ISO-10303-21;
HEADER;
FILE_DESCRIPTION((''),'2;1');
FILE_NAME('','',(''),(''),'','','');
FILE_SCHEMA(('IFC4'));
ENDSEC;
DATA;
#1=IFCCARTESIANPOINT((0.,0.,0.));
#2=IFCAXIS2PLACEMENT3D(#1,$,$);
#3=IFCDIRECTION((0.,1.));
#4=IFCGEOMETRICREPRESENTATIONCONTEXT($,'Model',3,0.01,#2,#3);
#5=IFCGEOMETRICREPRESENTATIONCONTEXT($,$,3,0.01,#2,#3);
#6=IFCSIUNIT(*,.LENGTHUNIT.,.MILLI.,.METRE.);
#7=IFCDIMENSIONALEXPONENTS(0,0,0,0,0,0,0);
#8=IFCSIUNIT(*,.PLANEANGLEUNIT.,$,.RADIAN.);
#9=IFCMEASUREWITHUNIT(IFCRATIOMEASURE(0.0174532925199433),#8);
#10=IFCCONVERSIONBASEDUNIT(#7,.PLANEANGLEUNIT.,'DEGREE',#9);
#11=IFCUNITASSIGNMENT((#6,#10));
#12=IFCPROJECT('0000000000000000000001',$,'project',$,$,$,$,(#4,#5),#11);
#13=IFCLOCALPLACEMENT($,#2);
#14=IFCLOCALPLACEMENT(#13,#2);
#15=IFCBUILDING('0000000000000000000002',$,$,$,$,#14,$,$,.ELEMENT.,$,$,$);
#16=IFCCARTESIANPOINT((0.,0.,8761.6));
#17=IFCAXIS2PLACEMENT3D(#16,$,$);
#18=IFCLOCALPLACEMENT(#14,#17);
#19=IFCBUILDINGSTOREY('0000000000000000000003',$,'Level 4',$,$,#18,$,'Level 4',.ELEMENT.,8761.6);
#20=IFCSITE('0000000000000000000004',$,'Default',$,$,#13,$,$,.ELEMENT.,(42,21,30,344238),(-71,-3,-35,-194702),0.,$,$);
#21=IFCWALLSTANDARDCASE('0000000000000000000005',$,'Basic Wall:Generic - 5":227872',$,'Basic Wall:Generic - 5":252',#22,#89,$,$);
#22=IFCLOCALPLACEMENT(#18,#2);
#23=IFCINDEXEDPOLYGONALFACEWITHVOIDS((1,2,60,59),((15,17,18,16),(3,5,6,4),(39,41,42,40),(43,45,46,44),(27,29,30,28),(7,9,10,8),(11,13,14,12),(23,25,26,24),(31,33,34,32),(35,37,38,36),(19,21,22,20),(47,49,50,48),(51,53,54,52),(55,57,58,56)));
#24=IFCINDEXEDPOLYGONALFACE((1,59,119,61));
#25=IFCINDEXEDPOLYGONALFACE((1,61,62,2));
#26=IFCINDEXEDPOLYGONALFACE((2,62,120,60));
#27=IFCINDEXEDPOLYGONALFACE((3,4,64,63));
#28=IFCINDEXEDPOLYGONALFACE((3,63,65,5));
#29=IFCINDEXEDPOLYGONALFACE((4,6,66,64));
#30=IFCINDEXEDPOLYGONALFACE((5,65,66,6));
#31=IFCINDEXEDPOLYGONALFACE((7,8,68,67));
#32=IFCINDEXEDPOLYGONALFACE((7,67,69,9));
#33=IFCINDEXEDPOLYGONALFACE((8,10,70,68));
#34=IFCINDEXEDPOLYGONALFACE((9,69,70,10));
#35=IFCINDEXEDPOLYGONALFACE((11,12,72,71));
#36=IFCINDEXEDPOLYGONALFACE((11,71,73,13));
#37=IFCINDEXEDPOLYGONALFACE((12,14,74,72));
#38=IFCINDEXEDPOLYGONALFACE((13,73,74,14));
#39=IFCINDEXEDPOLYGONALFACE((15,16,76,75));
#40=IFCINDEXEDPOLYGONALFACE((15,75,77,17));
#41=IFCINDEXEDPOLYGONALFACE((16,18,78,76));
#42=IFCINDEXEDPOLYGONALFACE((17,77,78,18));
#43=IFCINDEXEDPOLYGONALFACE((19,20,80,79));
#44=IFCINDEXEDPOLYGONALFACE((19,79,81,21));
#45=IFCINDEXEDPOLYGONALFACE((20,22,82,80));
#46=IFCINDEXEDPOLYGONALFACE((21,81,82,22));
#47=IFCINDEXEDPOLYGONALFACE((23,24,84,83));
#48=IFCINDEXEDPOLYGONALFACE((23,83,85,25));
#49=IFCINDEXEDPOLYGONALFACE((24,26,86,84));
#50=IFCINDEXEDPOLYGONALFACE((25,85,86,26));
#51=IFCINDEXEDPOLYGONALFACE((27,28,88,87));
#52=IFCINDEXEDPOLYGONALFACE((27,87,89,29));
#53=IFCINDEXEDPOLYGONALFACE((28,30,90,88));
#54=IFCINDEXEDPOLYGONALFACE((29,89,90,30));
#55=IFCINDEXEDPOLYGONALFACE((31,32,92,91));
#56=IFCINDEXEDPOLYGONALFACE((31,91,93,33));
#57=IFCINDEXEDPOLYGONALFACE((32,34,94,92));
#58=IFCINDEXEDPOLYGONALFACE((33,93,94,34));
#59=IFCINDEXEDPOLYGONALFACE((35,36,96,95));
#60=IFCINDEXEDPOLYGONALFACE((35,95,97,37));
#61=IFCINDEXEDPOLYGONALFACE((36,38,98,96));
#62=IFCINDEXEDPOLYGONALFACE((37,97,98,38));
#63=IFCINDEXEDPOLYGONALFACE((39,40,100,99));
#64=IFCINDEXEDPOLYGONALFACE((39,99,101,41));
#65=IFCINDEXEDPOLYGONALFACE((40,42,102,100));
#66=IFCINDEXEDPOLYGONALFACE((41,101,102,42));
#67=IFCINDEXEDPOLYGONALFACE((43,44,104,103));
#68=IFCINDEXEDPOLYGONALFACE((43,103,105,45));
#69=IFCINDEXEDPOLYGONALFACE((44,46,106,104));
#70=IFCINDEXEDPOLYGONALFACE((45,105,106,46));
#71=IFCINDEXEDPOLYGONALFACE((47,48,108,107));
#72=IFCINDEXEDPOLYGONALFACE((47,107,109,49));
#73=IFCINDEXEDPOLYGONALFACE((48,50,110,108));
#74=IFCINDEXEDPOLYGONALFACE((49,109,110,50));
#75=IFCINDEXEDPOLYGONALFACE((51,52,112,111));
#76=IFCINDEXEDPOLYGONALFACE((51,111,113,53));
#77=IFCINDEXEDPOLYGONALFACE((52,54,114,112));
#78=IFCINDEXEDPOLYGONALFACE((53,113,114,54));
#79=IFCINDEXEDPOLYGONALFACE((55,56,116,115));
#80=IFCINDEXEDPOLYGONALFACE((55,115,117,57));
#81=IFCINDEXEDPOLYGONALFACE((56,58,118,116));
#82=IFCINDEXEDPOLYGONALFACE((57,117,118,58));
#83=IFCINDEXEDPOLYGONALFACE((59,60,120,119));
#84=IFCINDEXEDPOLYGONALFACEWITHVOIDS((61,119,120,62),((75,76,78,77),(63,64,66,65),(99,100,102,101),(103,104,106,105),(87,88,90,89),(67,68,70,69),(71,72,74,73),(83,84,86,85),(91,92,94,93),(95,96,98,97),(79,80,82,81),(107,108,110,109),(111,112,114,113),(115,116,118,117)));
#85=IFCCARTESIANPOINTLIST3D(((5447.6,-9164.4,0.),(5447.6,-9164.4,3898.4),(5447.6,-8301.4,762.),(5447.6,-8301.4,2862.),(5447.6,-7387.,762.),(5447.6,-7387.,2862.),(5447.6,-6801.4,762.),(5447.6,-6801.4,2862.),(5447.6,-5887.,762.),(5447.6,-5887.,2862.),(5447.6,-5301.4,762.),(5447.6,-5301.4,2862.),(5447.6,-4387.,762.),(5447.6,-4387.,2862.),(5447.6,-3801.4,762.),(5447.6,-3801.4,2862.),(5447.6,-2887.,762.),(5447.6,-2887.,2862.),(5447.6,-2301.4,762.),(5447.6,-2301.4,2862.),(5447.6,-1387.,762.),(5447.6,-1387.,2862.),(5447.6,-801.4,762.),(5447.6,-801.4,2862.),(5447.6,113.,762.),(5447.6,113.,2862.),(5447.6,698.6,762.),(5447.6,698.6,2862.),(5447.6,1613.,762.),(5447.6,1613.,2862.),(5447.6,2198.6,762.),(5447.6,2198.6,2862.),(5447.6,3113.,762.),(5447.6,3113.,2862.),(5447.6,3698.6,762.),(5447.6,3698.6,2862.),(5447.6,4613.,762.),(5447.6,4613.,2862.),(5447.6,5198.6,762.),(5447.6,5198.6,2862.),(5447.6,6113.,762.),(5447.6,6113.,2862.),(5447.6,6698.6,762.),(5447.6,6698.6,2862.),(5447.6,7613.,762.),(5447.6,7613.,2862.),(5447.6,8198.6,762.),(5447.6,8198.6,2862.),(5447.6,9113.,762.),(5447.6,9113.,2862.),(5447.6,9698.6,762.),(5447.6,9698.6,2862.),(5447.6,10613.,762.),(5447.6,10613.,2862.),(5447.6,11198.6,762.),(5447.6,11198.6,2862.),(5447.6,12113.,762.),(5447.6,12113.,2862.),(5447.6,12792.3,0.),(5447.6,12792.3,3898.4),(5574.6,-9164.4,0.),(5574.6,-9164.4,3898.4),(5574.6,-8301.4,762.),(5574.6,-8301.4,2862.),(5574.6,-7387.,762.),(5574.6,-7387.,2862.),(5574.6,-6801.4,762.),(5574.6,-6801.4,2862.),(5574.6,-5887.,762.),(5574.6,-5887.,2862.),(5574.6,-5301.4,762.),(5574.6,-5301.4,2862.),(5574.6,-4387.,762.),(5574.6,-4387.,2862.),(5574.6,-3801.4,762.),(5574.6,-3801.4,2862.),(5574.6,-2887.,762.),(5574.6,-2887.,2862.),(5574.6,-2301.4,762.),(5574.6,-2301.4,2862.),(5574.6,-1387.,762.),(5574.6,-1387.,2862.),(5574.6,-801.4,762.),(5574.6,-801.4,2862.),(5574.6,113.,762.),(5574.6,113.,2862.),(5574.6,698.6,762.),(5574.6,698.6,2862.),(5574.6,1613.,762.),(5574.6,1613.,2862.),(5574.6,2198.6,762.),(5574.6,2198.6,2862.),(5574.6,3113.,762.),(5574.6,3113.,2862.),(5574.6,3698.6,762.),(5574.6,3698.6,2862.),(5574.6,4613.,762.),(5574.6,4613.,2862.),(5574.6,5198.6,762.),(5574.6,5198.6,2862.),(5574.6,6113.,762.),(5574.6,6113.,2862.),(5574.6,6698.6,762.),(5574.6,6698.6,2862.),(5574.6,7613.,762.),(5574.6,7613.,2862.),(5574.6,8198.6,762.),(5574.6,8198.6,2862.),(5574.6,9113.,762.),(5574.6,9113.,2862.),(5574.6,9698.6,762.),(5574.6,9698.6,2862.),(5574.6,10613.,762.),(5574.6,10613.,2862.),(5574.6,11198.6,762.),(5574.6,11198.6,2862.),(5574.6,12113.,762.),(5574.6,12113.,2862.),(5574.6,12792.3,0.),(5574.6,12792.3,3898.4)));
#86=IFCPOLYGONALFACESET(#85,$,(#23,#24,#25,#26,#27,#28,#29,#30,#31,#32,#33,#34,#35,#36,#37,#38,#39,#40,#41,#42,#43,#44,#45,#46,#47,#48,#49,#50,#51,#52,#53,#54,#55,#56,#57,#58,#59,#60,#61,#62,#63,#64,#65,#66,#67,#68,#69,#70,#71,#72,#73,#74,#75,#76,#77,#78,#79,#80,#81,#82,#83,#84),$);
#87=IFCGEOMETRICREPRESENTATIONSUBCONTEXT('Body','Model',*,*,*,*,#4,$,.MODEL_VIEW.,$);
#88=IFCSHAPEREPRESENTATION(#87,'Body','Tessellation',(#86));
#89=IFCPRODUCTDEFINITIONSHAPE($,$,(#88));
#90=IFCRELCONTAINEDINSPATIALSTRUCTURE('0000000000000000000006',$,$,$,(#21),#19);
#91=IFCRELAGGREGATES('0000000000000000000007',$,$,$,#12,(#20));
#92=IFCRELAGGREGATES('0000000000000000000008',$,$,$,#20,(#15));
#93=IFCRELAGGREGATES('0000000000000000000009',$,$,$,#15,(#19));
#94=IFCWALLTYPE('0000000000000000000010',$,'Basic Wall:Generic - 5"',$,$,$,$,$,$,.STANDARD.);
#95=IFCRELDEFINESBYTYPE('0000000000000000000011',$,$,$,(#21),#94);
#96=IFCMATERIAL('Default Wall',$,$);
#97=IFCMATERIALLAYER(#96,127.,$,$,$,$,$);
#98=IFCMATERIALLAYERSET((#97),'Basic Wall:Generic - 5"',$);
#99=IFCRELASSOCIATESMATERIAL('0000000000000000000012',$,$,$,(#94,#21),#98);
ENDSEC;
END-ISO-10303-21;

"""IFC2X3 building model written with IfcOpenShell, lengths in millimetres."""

from ifc_helpers import new_model, entity, si_unit, converted_unit, direction, frame, frame_2d, origin, place, context, subcontext, project, spatial, polyline, rectangle, extrude, clip, bounded_halfspace, material, layer, layer_set, layer_usage, type_object, element, save


model = new_model("IFC2X3")

# Units and contexts
model_context = context("Model", 3, precision=0.01, world=origin(), true_north=direction((0.0, 1.0)))
context_of_model = context(None, 3, precision=0.01, world=origin(), true_north=direction((0.0, 1.0)))
body_context = subcontext(model_context, "Body", "Model", "MODEL_VIEW")
ifc_project = project(units=[si_unit("LENGTHUNIT", "METRE", prefix="MILLI"), converted_unit("PLANEANGLEUNIT", "DEGREE", entity("IfcRatioMeasure", 0.0174532925199433), si_unit("PLANEANGLEUNIT", "RADIAN"), dimensions=[0, 0, 0, 0, 0, 0, 0])], contexts=[model_context, context_of_model])

# Site, building, storey
site_placement = place(None, origin())
site = spatial("IfcSite", under=ifc_project, at=site_placement, Name="Default", CompositionType="ELEMENT", RefLatitude=(42, 21, 30, 344238), RefLongitude=(-71, -3, -35, -194702), RefElevation=0.0)
building_placement = place(site_placement, origin())
building = spatial("IfcBuilding", under=site, at=building_placement, CompositionType="ELEMENT")
storey_placement = place(building_placement, frame((0.0, 0.0, 8761.6)))
storey = spatial("IfcBuildingStorey", under=building, at=storey_placement, Name="Level 4", LongName="Level 4", CompositionType="ELEMENT", Elevation=8761.6)

# Wall, openings
ifc_material_1 = material(Name="Default Wall")
ifc_layer_1 = layer(ifc_material_1, 127.0)
ifc_layer_set_1 = layer_set([ifc_layer_1], Name="Basic Wall:Generic - 5\"")
wall_type = type_object("IfcWallType", Name="Basic Wall:Generic - 5\"", PredefinedType="STANDARD", material=ifc_layer_set_1)
ifc_layer_usage_1 = layer_usage(ifc_layer_set_1, "AXIS2", "NEGATIVE", 63.5)
wall_1_placement = place(storey_placement, frame((5511.1, 12792.3, 0.0), z_axis=(0.0, 0.0, 1.0), x_axis=(0.0, -1.0, 0.0)))
wall_1 = element("IfcWallStandardCase", 1, at=wall_1_placement, inside=storey, type_object=wall_type, material=ifc_layer_usage_1, Name="Basic Wall:Generic - 5\":227872", ObjectType="Basic Wall:Generic - 5\":252", context=body_context, shape_type="Clipping", body=[
    clip(extrude(rectangle(XDim=21956.7, YDim=127.0, at=frame_2d((10978.4, 0.0), x_axis=(-1.0, 0.0))), origin(), (0.0, 0.0, 1.0), 3898.4), bounded_halfspace(frame((0.0, -63.5, 3898.4), z_axis=(0.0, 0.0, -1.0), x_axis=(1.0, 0.0, 0.0)), True, frame((0.0, -63.5, 3898.4)), polyline([(0.0, 0.0), (21829.7, 0.0), (21956.7, 0.0), (21956.7, 127.0), (0.0, 127.0), (0.0, 0.0)]))),
])
opening_1_placement = place(wall_1_placement, frame((679.3, -63.5, 762.0)))
element("IfcOpeningElement", 2, at=opening_1_placement, cuts=wall_1, ObjectType="Opening", context=body_context, shape_type="SweptSolid", body=[
    extrude(rectangle(XDim=2100.0, YDim=914.4, at=frame_2d((1050.0, 457.2), x_axis=(-1.0, 0.0))), frame((0.0, 0.0, 0.0), z_axis=(0.0, 1.0, 0.0), x_axis=(0.0, 0.0, 1.0)), (0.0, 0.0, 1.0), 127.0),
])
opening_2_placement = place(wall_1_placement, frame((3679.3, -63.5, 762.0)))
element("IfcOpeningElement", 3, at=opening_2_placement, cuts=wall_1, ObjectType="Opening", context=body_context, shape_type="SweptSolid", body=[
    extrude(rectangle(XDim=2100.0, YDim=914.4, at=frame_2d((1050.0, 457.2), x_axis=(-1.0, 0.0))), frame((0.0, 0.0, 0.0), z_axis=(0.0, 1.0, 0.0), x_axis=(0.0, 0.0, 1.0)), (0.0, 0.0, 1.0), 127.0),
])
opening_3_placement = place(wall_1_placement, frame((6679.3, -63.5, 762.0)))
element("IfcOpeningElement", 4, at=opening_3_placement, cuts=wall_1, ObjectType="Opening", context=body_context, shape_type="SweptSolid", body=[
    extrude(rectangle(XDim=2100.0, YDim=914.4, at=frame_2d((1050.0, 457.2), x_axis=(-1.0, 0.0))), frame((0.0, 0.0, 0.0), z_axis=(0.0, 1.0, 0.0), x_axis=(0.0, 0.0, 1.0)), (0.0, 0.0, 1.0), 127.0),
])
opening_4_placement = place(wall_1_placement, frame((9679.3, -63.5, 762.0)))
element("IfcOpeningElement", 5, at=opening_4_placement, cuts=wall_1, ObjectType="Opening", context=body_context, shape_type="SweptSolid", body=[
    extrude(rectangle(XDim=2100.0, YDim=914.4, at=frame_2d((1050.0, 457.2), x_axis=(-1.0, 0.0))), frame((0.0, 0.0, 0.0), z_axis=(0.0, 1.0, 0.0), x_axis=(0.0, 0.0, 1.0)), (0.0, 0.0, 1.0), 127.0),
])
opening_5_placement = place(wall_1_placement, frame((12679.3, -63.5, 762.0)))
element("IfcOpeningElement", 6, at=opening_5_placement, cuts=wall_1, ObjectType="Opening", context=body_context, shape_type="SweptSolid", body=[
    extrude(rectangle(XDim=2100.0, YDim=914.4, at=frame_2d((1050.0, 457.2), x_axis=(-1.0, 0.0))), frame((0.0, 0.0, 0.0), z_axis=(0.0, 1.0, 0.0), x_axis=(0.0, 0.0, 1.0)), (0.0, 0.0, 1.0), 127.0),
])
opening_6_placement = place(wall_1_placement, frame((15679.3, -63.5, 762.0)))
element("IfcOpeningElement", 7, at=opening_6_placement, cuts=wall_1, ObjectType="Opening", context=body_context, shape_type="SweptSolid", body=[
    extrude(rectangle(XDim=2100.0, YDim=914.4, at=frame_2d((1050.0, 457.2), x_axis=(-1.0, 0.0))), frame((0.0, 0.0, 0.0), z_axis=(0.0, 1.0, 0.0), x_axis=(0.0, 0.0, 1.0)), (0.0, 0.0, 1.0), 127.0),
])
opening_7_placement = place(wall_1_placement, frame((18679.3, -63.5, 762.0)))
element("IfcOpeningElement", 8, at=opening_7_placement, cuts=wall_1, ObjectType="Opening", context=body_context, shape_type="SweptSolid", body=[
    extrude(rectangle(XDim=2100.0, YDim=914.4, at=frame_2d((1050.0, 457.2), x_axis=(-1.0, 0.0))), frame((0.0, 0.0, 0.0), z_axis=(0.0, 1.0, 0.0), x_axis=(0.0, 0.0, 1.0)), (0.0, 0.0, 1.0), 127.0),
])
opening_8_placement = place(wall_1_placement, frame((2179.3, -63.5, 762.0)))
element("IfcOpeningElement", 9, at=opening_8_placement, cuts=wall_1, ObjectType="Opening", context=body_context, shape_type="SweptSolid", body=[
    extrude(rectangle(XDim=2100.0, YDim=914.4, at=frame_2d((1050.0, 457.2), x_axis=(-1.0, 0.0))), frame((0.0, 0.0, 0.0), z_axis=(0.0, 1.0, 0.0), x_axis=(0.0, 0.0, 1.0)), (0.0, 0.0, 1.0), 127.0),
])
opening_9_placement = place(wall_1_placement, frame((5179.3, -63.5, 762.0)))
element("IfcOpeningElement", 10, at=opening_9_placement, cuts=wall_1, ObjectType="Opening", context=body_context, shape_type="SweptSolid", body=[
    extrude(rectangle(XDim=2100.0, YDim=914.4, at=frame_2d((1050.0, 457.2), x_axis=(-1.0, 0.0))), frame((0.0, 0.0, 0.0), z_axis=(0.0, 1.0, 0.0), x_axis=(0.0, 0.0, 1.0)), (0.0, 0.0, 1.0), 127.0),
])
opening_10_placement = place(wall_1_placement, frame((8179.3, -63.5, 762.0)))
element("IfcOpeningElement", 11, at=opening_10_placement, cuts=wall_1, ObjectType="Opening", context=body_context, shape_type="SweptSolid", body=[
    extrude(rectangle(XDim=2100.0, YDim=914.4, at=frame_2d((1050.0, 457.2), x_axis=(-1.0, 0.0))), frame((0.0, 0.0, 0.0), z_axis=(0.0, 1.0, 0.0), x_axis=(0.0, 0.0, 1.0)), (0.0, 0.0, 1.0), 127.0),
])
opening_11_placement = place(wall_1_placement, frame((11179.3, -63.5, 762.0)))
element("IfcOpeningElement", 12, at=opening_11_placement, cuts=wall_1, ObjectType="Opening", context=body_context, shape_type="SweptSolid", body=[
    extrude(rectangle(XDim=2100.0, YDim=914.4, at=frame_2d((1050.0, 457.2), x_axis=(-1.0, 0.0))), frame((0.0, 0.0, 0.0), z_axis=(0.0, 1.0, 0.0), x_axis=(0.0, 0.0, 1.0)), (0.0, 0.0, 1.0), 127.0),
])
opening_12_placement = place(wall_1_placement, frame((14179.3, -63.5, 762.0)))
element("IfcOpeningElement", 13, at=opening_12_placement, cuts=wall_1, ObjectType="Opening", context=body_context, shape_type="SweptSolid", body=[
    extrude(rectangle(XDim=2100.0, YDim=914.4, at=frame_2d((1050.0, 457.2), x_axis=(-1.0, 0.0))), frame((0.0, 0.0, 0.0), z_axis=(0.0, 1.0, 0.0), x_axis=(0.0, 0.0, 1.0)), (0.0, 0.0, 1.0), 127.0),
])
opening_13_placement = place(wall_1_placement, frame((17179.3, -63.5, 762.0)))
element("IfcOpeningElement", 14, at=opening_13_placement, cuts=wall_1, ObjectType="Opening", context=body_context, shape_type="SweptSolid", body=[
    extrude(rectangle(XDim=2100.0, YDim=914.4, at=frame_2d((1050.0, 457.2), x_axis=(-1.0, 0.0))), frame((0.0, 0.0, 0.0), z_axis=(0.0, 1.0, 0.0), x_axis=(0.0, 0.0, 1.0)), (0.0, 0.0, 1.0), 127.0),
])
opening_14_placement = place(wall_1_placement, frame((20179.3, -63.5, 762.0)))
element("IfcOpeningElement", 15, at=opening_14_placement, cuts=wall_1, ObjectType="Opening", context=body_context, shape_type="SweptSolid", body=[
    extrude(rectangle(XDim=2100.0, YDim=914.4, at=frame_2d((1050.0, 457.2), x_axis=(-1.0, 0.0))), frame((0.0, 0.0, 0.0), z_axis=(0.0, 1.0, 0.0), x_axis=(0.0, 0.0, 1.0)), (0.0, 0.0, 1.0), 127.0),
])

save(model, "model.ifc")
